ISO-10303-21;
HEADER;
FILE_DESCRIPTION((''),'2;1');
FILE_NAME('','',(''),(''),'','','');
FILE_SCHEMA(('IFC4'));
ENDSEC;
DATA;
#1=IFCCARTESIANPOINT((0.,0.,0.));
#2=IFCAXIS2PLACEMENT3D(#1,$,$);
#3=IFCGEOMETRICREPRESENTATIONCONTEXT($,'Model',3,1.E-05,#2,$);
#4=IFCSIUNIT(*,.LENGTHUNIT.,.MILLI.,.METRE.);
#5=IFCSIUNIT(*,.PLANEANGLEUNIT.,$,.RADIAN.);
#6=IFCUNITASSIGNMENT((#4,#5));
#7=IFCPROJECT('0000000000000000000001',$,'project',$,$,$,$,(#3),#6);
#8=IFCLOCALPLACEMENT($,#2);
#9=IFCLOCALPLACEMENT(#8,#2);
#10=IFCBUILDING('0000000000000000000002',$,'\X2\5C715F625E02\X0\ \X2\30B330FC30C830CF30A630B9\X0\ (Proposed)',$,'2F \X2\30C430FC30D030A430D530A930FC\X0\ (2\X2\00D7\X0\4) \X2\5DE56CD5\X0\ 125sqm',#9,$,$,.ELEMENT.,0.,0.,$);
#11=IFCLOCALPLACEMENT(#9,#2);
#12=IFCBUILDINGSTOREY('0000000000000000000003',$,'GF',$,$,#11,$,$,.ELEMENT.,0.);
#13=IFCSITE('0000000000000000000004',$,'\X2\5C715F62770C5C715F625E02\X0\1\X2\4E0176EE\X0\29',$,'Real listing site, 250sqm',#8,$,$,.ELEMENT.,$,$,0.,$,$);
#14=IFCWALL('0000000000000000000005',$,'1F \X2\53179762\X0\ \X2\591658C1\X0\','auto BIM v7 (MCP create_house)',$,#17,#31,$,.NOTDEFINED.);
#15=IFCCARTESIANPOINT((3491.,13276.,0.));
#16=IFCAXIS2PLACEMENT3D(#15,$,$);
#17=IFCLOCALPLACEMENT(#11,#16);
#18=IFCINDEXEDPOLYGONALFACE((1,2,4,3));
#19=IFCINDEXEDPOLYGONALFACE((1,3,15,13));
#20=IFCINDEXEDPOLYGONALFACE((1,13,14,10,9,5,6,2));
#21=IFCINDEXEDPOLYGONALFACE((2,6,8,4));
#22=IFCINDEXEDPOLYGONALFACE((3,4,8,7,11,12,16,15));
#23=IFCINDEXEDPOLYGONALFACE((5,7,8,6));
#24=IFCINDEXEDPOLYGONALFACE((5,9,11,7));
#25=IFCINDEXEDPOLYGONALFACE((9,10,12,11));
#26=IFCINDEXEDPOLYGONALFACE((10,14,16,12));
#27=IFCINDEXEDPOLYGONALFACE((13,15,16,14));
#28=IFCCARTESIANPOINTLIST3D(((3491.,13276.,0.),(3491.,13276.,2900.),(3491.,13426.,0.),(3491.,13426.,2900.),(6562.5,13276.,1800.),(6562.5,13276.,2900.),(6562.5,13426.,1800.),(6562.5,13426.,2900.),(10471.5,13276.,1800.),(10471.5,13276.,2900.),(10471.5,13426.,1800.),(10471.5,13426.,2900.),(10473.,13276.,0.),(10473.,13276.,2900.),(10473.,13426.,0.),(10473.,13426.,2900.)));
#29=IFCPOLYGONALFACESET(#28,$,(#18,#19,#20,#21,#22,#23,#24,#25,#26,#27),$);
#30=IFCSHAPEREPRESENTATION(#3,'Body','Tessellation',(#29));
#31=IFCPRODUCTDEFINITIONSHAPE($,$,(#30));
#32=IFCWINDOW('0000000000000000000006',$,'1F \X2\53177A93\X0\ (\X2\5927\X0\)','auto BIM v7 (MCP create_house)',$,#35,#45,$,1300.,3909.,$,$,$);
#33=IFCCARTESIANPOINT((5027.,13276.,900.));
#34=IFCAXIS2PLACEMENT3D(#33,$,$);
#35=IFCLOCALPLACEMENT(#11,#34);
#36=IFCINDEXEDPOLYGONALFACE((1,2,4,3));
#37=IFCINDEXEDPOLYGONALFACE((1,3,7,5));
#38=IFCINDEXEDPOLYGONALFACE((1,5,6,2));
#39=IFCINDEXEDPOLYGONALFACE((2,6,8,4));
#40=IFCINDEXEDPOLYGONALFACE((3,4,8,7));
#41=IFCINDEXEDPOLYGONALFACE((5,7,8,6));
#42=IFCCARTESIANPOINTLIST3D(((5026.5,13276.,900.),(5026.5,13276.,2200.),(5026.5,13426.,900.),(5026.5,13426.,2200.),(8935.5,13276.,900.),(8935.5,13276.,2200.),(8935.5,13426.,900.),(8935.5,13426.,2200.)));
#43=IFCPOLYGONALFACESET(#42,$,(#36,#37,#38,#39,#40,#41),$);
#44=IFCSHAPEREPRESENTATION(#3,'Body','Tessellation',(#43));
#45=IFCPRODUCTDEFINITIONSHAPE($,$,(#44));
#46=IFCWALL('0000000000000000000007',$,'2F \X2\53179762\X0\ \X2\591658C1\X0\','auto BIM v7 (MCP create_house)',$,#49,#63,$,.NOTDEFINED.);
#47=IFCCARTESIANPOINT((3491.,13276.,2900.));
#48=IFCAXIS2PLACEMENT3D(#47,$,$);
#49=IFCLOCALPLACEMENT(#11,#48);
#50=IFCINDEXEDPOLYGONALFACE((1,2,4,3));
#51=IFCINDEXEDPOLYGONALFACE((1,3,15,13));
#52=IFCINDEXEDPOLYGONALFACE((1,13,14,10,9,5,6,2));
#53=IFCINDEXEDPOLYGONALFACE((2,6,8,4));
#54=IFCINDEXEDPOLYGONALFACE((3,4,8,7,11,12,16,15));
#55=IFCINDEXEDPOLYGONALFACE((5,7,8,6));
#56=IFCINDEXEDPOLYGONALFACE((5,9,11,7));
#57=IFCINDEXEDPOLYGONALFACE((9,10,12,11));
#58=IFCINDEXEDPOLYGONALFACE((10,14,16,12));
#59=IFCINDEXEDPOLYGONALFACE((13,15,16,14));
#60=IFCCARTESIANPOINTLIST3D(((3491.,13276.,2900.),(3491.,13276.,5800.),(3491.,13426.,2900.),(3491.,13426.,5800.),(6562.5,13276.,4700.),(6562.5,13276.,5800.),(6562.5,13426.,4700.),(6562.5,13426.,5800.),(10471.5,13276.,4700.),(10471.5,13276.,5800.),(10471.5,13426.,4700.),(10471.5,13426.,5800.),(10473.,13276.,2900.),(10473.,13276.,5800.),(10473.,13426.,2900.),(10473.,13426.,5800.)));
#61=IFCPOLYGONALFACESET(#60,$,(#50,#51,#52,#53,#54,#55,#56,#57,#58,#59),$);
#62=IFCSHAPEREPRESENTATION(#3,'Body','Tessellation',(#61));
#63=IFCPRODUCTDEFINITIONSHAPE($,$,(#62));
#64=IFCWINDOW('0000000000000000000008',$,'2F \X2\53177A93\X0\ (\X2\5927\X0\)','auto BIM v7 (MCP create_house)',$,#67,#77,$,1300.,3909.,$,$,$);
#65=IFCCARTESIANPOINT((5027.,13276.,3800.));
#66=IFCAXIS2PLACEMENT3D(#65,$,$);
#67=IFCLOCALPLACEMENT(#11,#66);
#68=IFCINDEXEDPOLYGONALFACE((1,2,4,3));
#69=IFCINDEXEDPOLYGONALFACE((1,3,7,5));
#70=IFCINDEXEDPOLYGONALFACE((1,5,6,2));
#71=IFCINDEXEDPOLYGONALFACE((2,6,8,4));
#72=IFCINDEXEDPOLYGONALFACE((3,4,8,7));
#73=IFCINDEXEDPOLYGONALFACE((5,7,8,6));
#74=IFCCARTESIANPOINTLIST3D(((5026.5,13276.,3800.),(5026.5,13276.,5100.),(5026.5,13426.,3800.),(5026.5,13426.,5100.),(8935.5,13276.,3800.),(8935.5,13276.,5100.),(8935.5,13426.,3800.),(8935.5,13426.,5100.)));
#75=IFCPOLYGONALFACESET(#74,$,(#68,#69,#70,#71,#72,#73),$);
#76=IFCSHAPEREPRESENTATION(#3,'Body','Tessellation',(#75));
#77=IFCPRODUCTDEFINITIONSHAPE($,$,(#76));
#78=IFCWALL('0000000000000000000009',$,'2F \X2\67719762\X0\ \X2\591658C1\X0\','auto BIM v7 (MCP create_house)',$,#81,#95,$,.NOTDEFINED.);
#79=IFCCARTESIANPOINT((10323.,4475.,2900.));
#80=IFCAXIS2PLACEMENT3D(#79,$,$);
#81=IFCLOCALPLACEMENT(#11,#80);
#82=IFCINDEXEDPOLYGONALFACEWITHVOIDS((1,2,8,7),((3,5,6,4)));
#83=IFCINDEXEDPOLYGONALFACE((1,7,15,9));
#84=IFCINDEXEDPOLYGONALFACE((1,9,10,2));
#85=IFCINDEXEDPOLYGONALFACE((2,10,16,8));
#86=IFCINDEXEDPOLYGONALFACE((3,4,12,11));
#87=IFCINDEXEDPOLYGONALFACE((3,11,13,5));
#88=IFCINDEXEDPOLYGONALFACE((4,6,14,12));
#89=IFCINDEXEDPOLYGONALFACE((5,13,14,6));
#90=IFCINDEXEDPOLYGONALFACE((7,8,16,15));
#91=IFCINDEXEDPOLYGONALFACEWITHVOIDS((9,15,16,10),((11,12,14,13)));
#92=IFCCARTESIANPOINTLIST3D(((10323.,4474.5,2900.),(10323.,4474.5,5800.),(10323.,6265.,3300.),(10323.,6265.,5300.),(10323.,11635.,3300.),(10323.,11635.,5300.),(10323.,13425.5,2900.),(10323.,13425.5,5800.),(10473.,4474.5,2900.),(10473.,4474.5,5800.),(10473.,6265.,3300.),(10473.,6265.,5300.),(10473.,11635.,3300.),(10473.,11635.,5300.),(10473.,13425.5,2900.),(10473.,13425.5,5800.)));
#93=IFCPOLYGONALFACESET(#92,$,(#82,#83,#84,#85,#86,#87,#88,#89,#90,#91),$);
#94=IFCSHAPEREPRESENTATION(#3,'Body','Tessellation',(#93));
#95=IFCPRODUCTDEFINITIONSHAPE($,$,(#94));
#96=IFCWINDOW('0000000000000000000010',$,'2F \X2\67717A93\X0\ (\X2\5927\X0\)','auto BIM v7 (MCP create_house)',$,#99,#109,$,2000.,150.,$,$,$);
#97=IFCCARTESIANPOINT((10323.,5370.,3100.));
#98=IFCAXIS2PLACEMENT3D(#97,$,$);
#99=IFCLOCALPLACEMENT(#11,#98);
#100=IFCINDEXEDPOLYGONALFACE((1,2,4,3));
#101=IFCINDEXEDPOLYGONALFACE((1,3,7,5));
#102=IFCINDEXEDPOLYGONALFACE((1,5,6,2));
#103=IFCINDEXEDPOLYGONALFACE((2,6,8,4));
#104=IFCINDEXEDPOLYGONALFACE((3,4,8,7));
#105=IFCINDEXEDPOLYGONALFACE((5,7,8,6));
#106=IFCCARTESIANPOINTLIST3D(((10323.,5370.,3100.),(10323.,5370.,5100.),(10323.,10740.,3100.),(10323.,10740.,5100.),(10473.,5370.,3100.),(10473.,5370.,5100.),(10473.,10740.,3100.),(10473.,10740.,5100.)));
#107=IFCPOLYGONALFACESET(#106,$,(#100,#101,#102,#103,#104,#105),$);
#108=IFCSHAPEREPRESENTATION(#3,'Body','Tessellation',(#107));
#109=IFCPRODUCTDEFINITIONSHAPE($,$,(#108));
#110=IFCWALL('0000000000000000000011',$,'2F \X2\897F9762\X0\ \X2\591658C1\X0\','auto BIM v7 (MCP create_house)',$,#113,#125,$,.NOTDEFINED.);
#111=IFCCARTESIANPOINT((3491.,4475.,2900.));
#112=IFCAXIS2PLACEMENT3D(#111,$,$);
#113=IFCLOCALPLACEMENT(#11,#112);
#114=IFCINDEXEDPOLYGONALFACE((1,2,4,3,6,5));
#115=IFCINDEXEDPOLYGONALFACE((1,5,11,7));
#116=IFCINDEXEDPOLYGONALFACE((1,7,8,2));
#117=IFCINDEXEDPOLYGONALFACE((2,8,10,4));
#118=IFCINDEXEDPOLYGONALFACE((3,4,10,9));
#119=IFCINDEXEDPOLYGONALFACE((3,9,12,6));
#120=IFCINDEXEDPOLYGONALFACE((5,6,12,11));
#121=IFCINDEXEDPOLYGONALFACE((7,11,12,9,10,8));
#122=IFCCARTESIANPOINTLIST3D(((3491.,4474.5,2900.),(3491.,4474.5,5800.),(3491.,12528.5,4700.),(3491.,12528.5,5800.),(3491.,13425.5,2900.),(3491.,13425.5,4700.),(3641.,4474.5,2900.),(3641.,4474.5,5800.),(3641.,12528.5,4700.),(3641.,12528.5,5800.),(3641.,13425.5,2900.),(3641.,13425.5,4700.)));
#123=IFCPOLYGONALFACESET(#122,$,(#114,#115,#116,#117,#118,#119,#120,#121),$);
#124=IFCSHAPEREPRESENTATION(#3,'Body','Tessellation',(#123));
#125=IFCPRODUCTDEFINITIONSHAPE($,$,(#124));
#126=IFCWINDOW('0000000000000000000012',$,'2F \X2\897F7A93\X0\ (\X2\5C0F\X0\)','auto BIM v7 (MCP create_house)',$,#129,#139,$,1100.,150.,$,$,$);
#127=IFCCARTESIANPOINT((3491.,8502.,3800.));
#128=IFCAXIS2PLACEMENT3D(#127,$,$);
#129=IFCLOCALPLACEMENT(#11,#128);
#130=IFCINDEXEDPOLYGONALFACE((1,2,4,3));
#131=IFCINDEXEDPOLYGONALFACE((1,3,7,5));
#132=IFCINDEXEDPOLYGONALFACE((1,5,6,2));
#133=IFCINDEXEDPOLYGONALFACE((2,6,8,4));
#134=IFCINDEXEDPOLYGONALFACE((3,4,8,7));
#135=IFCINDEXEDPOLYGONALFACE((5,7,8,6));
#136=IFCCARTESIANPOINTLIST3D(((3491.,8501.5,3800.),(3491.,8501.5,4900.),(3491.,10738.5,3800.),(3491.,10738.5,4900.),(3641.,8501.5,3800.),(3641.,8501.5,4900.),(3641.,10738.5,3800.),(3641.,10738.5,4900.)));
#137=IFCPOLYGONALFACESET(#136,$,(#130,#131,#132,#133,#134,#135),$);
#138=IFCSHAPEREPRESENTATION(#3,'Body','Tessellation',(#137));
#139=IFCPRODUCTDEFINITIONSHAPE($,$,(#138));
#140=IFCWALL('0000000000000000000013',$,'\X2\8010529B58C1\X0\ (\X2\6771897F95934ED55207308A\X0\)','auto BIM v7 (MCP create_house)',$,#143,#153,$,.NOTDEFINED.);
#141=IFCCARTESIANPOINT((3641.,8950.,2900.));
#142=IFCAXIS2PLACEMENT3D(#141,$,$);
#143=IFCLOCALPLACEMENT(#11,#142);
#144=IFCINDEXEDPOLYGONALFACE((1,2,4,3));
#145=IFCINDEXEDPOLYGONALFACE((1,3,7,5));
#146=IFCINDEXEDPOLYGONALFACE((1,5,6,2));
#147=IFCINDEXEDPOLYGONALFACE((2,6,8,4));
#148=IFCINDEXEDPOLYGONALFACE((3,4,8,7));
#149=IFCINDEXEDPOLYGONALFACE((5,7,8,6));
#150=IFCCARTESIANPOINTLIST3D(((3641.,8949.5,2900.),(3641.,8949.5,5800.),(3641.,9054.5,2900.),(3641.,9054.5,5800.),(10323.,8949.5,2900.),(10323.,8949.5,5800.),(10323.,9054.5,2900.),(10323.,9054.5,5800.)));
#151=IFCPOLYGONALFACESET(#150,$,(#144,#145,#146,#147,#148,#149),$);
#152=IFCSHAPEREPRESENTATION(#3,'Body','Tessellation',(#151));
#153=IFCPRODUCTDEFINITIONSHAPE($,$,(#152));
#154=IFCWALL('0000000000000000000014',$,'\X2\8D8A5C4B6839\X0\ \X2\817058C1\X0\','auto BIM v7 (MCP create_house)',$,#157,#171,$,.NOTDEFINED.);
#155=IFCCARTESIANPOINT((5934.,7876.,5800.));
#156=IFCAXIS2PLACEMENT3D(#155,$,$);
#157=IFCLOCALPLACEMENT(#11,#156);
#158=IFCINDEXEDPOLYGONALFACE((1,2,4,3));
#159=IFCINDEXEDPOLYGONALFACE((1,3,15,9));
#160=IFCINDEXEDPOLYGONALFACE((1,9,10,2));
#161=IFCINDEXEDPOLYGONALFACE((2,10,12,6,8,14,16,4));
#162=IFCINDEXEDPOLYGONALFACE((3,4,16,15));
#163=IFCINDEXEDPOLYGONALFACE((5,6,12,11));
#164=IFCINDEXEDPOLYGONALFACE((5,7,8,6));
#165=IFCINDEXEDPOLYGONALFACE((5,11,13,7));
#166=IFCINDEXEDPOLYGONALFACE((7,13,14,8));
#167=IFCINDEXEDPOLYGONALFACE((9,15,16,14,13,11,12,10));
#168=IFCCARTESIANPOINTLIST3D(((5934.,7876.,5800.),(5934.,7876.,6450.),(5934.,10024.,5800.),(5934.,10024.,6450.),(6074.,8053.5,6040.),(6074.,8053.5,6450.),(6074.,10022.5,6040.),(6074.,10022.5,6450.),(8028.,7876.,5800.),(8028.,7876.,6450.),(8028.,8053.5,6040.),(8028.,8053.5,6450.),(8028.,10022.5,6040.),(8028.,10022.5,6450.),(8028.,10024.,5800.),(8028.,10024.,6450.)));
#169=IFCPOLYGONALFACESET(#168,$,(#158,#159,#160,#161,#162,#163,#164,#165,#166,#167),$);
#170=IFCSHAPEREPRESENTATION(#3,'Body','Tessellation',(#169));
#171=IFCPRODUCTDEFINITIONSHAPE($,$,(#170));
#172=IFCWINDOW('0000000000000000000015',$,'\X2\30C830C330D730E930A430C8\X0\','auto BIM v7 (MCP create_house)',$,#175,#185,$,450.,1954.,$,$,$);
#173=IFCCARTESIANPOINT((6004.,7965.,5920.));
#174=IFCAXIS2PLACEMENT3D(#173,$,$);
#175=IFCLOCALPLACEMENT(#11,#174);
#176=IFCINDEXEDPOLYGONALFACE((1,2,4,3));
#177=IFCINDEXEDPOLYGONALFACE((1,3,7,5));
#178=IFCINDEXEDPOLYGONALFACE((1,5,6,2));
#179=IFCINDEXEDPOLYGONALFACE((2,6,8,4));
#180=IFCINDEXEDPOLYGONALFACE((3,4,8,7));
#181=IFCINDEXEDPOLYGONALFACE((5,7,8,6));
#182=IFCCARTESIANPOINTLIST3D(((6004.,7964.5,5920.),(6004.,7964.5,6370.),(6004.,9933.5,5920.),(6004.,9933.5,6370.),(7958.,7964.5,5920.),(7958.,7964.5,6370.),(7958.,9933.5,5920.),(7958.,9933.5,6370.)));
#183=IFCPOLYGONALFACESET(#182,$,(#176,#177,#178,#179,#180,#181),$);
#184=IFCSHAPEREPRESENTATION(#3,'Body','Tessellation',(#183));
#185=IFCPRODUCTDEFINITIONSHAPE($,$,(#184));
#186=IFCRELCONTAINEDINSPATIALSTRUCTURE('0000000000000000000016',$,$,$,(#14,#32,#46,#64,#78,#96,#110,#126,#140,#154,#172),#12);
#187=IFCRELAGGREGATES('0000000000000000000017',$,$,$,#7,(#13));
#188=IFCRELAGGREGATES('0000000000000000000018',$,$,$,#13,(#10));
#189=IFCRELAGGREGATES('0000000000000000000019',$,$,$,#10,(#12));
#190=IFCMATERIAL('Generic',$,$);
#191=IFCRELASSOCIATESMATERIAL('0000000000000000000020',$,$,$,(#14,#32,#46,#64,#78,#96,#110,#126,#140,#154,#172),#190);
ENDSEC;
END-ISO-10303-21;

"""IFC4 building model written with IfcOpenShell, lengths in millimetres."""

from ifc_helpers import new_model, si_unit, frame, frame_2d, origin, place, context, project, spatial, rectangle, extrude, material, element, fill, save


model = new_model("IFC4")

# Units and contexts
model_context = context("Model", 3, precision=1e-05, world=origin())
ifc_project = project(units=[si_unit("LENGTHUNIT", "METRE", prefix="MILLI"), si_unit("PLANEANGLEUNIT", "RADIAN")], contexts=[model_context])

# Site, building, storey
site_placement = place(None, origin())
site = spatial("IfcSite", under=ifc_project, at=site_placement, Name="山形県山形市1丁目29", ObjectType="Real listing site, 250sqm", CompositionType="ELEMENT", RefElevation=0.0)
building_placement = place(site_placement, origin())
building = spatial("IfcBuilding", under=site, at=building_placement, Name="山形市 コートハウス (Proposed)", ObjectType="2F ツーバイフォー (2×4) 工法 125sqm", CompositionType="ELEMENT", ElevationOfRefHeight=0.0, ElevationOfTerrain=0.0)
storey_placement = place(building_placement, origin())
storey = spatial("IfcBuildingStorey", under=building, at=storey_placement, Name="GF", CompositionType="ELEMENT", Elevation=0.0)

# Wall, opening, window
ifc_material = material(Name="Generic")
wall_1_placement = place(storey_placement, frame((3491.0, 13276.0, 0.0)))
wall_1 = element("IfcWall", 1, at=wall_1_placement, inside=storey, material=ifc_material, Name="1F 北面 外壁", Description="auto BIM v7 (MCP create_house)", PredefinedType="NOTDEFINED", context=model_context, shape_type="SweptSolid", body=[
    extrude(rectangle(XDim=6982.0, YDim=150.0, at=frame_2d((3491.0, 75.0))), frame((3491.0, 13276.0, 0.0)), (0.0, 0.0, 1.0), 2900.0),
])
opening_1_placement = place(storey_placement, frame((5027.0, 13276.0, 900.0)))
opening_1 = element("IfcOpeningElement", 2, at=opening_1_placement, cuts=wall_1, PredefinedType="NOTDEFINED", context=model_context, shape_type="SweptSolid", body=[
    extrude(rectangle(XDim=3909.0, YDim=150.0, at=frame_2d((1954.0, 75.0))), frame((5027.0, 13276.0, 900.0)), (0.0, 0.0, 1.0), 1300.0),
])
window_1_placement = place(storey_placement, frame((5027.0, 13276.0, 900.0)))
window_1 = element("IfcWindow", 3, at=window_1_placement, inside=storey, material=ifc_material, Name="1F 北窓 (大)", Description="auto BIM v7 (MCP create_house)", OverallHeight=1300.0, OverallWidth=3909.0, context=model_context, shape_type="SweptSolid", body=[
    extrude(rectangle(XDim=3909.0, YDim=150.0, at=frame_2d((1954.0, 75.0))), frame((5027.0, 13276.0, 900.0)), (0.0, 0.0, 1.0), 1300.0),
])
fill(opening_1, window_1)

# Walls, openings, windows
wall_2_placement = place(storey_placement, frame((3491.0, 13276.0, 2900.0)))
wall_2 = element("IfcWall", 4, at=wall_2_placement, inside=storey, material=ifc_material, Name="2F 北面 外壁", Description="auto BIM v7 (MCP create_house)", PredefinedType="NOTDEFINED", context=model_context, shape_type="SweptSolid", body=[
    extrude(rectangle(XDim=6982.0, YDim=150.0, at=frame_2d((3491.0, 75.0))), frame((3491.0, 13276.0, 2900.0)), (0.0, 0.0, 1.0), 2900.0),
])
opening_2_placement = place(storey_placement, frame((5027.0, 13276.0, 3800.0)))
opening_2 = element("IfcOpeningElement", 5, at=opening_2_placement, cuts=wall_2, PredefinedType="NOTDEFINED", context=model_context, shape_type="SweptSolid", body=[
    extrude(rectangle(XDim=3909.0, YDim=150.0, at=frame_2d((1954.0, 75.0))), frame((5027.0, 13276.0, 3800.0)), (0.0, 0.0, 1.0), 1300.0),
])
window_2_placement = place(storey_placement, frame((5027.0, 13276.0, 3800.0)))
window_2 = element("IfcWindow", 6, at=window_2_placement, inside=storey, material=ifc_material, Name="2F 北窓 (大)", Description="auto BIM v7 (MCP create_house)", OverallHeight=1300.0, OverallWidth=3909.0, context=model_context, shape_type="SweptSolid", body=[
    extrude(rectangle(XDim=3909.0, YDim=150.0, at=frame_2d((1954.0, 75.0))), frame((5027.0, 13276.0, 3800.0)), (0.0, 0.0, 1.0), 1300.0),
])
fill(opening_2, window_2)
wall_3_placement = place(storey_placement, frame((10323.0, 4475.0, 2900.0)))
wall_3 = element("IfcWall", 7, at=wall_3_placement, inside=storey, material=ifc_material, Name="2F 東面 外壁", Description="auto BIM v7 (MCP create_house)", PredefinedType="NOTDEFINED", context=model_context, shape_type="SweptSolid", body=[
    extrude(rectangle(XDim=150.0, YDim=8951.0, at=frame_2d((75.0, 4475.0))), frame((10323.0, 4475.0, 2900.0)), (0.0, 0.0, 1.0), 2900.0),
])
opening_3_placement = place(storey_placement, frame((10323.0, 5370.0, 3100.0)))
opening_3 = element("IfcOpeningElement", 8, at=opening_3_placement, cuts=wall_3, PredefinedType="NOTDEFINED", context=model_context, shape_type="SweptSolid", body=[
    extrude(rectangle(XDim=150.0, YDim=5370.0, at=frame_2d((75.0, 2685.0))), frame((10323.0, 5370.0, 3100.0)), (0.0, 0.0, 1.0), 2000.0),
])
window_3_placement = place(storey_placement, frame((10323.0, 5370.0, 3100.0)))
window_3 = element("IfcWindow", 9, at=window_3_placement, inside=storey, material=ifc_material, Name="2F 東窓 (大)", Description="auto BIM v7 (MCP create_house)", OverallHeight=2000.0, OverallWidth=150.0, context=model_context, shape_type="SweptSolid", body=[
    extrude(rectangle(XDim=150.0, YDim=5370.0, at=frame_2d((75.0, 2685.0))), frame((10323.0, 5370.0, 3100.0)), (0.0, 0.0, 1.0), 2000.0),
])
fill(opening_3, window_3)
wall_4_placement = place(storey_placement, frame((3491.0, 4475.0, 2900.0)))
wall_4 = element("IfcWall", 10, at=wall_4_placement, inside=storey, material=ifc_material, Name="2F 西面 外壁", Description="auto BIM v7 (MCP create_house)", PredefinedType="NOTDEFINED", context=model_context, shape_type="SweptSolid", body=[
    extrude(rectangle(XDim=150.0, YDim=8951.0, at=frame_2d((75.0, 4475.0))), frame((3491.0, 4475.0, 2900.0)), (0.0, 0.0, 1.0), 2900.0),
])
opening_4_placement = place(storey_placement, frame((3491.0, 8502.0, 3800.0)))
opening_4 = element("IfcOpeningElement", 11, at=opening_4_placement, cuts=wall_4, PredefinedType="NOTDEFINED", context=model_context, shape_type="SweptSolid", body=[
    extrude(rectangle(XDim=150.0, YDim=2237.0, at=frame_2d((75.0, 1118.0))), frame((3491.0, 8502.0, 3800.0)), (0.0, 0.0, 1.0), 1100.0),
])
window_4_placement = place(storey_placement, frame((3491.0, 8502.0, 3800.0)))
window_4 = element("IfcWindow", 12, at=window_4_placement, inside=storey, material=ifc_material, Name="2F 西窓 (小)", Description="auto BIM v7 (MCP create_house)", OverallHeight=1100.0, OverallWidth=150.0, context=model_context, shape_type="SweptSolid", body=[
    extrude(rectangle(XDim=150.0, YDim=2237.0, at=frame_2d((75.0, 1118.0))), frame((3491.0, 8502.0, 3800.0)), (0.0, 0.0, 1.0), 1100.0),
])
fill(opening_4, window_4)

# Wall
wall_5_placement = place(storey_placement, frame((3641.0, 8950.0, 2900.0)))
element("IfcWall", 13, at=wall_5_placement, inside=storey, material=ifc_material, Name="耐力壁 (東西間仕切り)", Description="auto BIM v7 (MCP create_house)", PredefinedType="NOTDEFINED", context=model_context, shape_type="SweptSolid", body=[
    extrude(rectangle(XDim=6682.0, YDim=105.0, at=frame_2d((3341.0, 52.0))), frame((3641.0, 8950.0, 2900.0)), (0.0, 0.0, 1.0), 2900.0),
])

# Wall, opening, window
wall_6_placement = place(storey_placement, frame((5934.0, 7876.0, 5800.0)))
wall_6 = element("IfcWall", 14, at=wall_6_placement, inside=storey, material=ifc_material, Name="越屋根 腰壁", Description="auto BIM v7 (MCP create_house)", PredefinedType="NOTDEFINED", context=model_context, shape_type="SweptSolid", body=[
    extrude(rectangle(XDim=2094.0, YDim=2148.0, at=frame_2d((1047.0, 1074.0))), frame((5934.0, 7876.0, 5800.0)), (0.0, 0.0, 1.0), 650.0),
])
opening_5_placement = place(storey_placement, frame((6004.0, 7965.0, 5920.0)))
opening_5 = element("IfcOpeningElement", 15, at=opening_5_placement, cuts=wall_6, PredefinedType="NOTDEFINED", context=model_context, shape_type="SweptSolid", body=[
    extrude(rectangle(XDim=1954.0, YDim=1969.0, at=frame_2d((977.0, 984.0))), frame((6004.0, 7965.0, 5920.0)), (0.0, 0.0, 1.0), 450.0),
])
window_5_placement = place(storey_placement, frame((6004.0, 7965.0, 5920.0)))
window_5 = element("IfcWindow", 16, at=window_5_placement, inside=storey, material=ifc_material, Name="トップライト", Description="auto BIM v7 (MCP create_house)", OverallHeight=450.0, OverallWidth=1954.0, context=model_context, shape_type="SweptSolid", body=[
    extrude(rectangle(XDim=1954.0, YDim=1969.0, at=frame_2d((977.0, 984.0))), frame((6004.0, 7965.0, 5920.0)), (0.0, 0.0, 1.0), 450.0),
])
fill(opening_5, window_5)

save(model, "model.ifc")
